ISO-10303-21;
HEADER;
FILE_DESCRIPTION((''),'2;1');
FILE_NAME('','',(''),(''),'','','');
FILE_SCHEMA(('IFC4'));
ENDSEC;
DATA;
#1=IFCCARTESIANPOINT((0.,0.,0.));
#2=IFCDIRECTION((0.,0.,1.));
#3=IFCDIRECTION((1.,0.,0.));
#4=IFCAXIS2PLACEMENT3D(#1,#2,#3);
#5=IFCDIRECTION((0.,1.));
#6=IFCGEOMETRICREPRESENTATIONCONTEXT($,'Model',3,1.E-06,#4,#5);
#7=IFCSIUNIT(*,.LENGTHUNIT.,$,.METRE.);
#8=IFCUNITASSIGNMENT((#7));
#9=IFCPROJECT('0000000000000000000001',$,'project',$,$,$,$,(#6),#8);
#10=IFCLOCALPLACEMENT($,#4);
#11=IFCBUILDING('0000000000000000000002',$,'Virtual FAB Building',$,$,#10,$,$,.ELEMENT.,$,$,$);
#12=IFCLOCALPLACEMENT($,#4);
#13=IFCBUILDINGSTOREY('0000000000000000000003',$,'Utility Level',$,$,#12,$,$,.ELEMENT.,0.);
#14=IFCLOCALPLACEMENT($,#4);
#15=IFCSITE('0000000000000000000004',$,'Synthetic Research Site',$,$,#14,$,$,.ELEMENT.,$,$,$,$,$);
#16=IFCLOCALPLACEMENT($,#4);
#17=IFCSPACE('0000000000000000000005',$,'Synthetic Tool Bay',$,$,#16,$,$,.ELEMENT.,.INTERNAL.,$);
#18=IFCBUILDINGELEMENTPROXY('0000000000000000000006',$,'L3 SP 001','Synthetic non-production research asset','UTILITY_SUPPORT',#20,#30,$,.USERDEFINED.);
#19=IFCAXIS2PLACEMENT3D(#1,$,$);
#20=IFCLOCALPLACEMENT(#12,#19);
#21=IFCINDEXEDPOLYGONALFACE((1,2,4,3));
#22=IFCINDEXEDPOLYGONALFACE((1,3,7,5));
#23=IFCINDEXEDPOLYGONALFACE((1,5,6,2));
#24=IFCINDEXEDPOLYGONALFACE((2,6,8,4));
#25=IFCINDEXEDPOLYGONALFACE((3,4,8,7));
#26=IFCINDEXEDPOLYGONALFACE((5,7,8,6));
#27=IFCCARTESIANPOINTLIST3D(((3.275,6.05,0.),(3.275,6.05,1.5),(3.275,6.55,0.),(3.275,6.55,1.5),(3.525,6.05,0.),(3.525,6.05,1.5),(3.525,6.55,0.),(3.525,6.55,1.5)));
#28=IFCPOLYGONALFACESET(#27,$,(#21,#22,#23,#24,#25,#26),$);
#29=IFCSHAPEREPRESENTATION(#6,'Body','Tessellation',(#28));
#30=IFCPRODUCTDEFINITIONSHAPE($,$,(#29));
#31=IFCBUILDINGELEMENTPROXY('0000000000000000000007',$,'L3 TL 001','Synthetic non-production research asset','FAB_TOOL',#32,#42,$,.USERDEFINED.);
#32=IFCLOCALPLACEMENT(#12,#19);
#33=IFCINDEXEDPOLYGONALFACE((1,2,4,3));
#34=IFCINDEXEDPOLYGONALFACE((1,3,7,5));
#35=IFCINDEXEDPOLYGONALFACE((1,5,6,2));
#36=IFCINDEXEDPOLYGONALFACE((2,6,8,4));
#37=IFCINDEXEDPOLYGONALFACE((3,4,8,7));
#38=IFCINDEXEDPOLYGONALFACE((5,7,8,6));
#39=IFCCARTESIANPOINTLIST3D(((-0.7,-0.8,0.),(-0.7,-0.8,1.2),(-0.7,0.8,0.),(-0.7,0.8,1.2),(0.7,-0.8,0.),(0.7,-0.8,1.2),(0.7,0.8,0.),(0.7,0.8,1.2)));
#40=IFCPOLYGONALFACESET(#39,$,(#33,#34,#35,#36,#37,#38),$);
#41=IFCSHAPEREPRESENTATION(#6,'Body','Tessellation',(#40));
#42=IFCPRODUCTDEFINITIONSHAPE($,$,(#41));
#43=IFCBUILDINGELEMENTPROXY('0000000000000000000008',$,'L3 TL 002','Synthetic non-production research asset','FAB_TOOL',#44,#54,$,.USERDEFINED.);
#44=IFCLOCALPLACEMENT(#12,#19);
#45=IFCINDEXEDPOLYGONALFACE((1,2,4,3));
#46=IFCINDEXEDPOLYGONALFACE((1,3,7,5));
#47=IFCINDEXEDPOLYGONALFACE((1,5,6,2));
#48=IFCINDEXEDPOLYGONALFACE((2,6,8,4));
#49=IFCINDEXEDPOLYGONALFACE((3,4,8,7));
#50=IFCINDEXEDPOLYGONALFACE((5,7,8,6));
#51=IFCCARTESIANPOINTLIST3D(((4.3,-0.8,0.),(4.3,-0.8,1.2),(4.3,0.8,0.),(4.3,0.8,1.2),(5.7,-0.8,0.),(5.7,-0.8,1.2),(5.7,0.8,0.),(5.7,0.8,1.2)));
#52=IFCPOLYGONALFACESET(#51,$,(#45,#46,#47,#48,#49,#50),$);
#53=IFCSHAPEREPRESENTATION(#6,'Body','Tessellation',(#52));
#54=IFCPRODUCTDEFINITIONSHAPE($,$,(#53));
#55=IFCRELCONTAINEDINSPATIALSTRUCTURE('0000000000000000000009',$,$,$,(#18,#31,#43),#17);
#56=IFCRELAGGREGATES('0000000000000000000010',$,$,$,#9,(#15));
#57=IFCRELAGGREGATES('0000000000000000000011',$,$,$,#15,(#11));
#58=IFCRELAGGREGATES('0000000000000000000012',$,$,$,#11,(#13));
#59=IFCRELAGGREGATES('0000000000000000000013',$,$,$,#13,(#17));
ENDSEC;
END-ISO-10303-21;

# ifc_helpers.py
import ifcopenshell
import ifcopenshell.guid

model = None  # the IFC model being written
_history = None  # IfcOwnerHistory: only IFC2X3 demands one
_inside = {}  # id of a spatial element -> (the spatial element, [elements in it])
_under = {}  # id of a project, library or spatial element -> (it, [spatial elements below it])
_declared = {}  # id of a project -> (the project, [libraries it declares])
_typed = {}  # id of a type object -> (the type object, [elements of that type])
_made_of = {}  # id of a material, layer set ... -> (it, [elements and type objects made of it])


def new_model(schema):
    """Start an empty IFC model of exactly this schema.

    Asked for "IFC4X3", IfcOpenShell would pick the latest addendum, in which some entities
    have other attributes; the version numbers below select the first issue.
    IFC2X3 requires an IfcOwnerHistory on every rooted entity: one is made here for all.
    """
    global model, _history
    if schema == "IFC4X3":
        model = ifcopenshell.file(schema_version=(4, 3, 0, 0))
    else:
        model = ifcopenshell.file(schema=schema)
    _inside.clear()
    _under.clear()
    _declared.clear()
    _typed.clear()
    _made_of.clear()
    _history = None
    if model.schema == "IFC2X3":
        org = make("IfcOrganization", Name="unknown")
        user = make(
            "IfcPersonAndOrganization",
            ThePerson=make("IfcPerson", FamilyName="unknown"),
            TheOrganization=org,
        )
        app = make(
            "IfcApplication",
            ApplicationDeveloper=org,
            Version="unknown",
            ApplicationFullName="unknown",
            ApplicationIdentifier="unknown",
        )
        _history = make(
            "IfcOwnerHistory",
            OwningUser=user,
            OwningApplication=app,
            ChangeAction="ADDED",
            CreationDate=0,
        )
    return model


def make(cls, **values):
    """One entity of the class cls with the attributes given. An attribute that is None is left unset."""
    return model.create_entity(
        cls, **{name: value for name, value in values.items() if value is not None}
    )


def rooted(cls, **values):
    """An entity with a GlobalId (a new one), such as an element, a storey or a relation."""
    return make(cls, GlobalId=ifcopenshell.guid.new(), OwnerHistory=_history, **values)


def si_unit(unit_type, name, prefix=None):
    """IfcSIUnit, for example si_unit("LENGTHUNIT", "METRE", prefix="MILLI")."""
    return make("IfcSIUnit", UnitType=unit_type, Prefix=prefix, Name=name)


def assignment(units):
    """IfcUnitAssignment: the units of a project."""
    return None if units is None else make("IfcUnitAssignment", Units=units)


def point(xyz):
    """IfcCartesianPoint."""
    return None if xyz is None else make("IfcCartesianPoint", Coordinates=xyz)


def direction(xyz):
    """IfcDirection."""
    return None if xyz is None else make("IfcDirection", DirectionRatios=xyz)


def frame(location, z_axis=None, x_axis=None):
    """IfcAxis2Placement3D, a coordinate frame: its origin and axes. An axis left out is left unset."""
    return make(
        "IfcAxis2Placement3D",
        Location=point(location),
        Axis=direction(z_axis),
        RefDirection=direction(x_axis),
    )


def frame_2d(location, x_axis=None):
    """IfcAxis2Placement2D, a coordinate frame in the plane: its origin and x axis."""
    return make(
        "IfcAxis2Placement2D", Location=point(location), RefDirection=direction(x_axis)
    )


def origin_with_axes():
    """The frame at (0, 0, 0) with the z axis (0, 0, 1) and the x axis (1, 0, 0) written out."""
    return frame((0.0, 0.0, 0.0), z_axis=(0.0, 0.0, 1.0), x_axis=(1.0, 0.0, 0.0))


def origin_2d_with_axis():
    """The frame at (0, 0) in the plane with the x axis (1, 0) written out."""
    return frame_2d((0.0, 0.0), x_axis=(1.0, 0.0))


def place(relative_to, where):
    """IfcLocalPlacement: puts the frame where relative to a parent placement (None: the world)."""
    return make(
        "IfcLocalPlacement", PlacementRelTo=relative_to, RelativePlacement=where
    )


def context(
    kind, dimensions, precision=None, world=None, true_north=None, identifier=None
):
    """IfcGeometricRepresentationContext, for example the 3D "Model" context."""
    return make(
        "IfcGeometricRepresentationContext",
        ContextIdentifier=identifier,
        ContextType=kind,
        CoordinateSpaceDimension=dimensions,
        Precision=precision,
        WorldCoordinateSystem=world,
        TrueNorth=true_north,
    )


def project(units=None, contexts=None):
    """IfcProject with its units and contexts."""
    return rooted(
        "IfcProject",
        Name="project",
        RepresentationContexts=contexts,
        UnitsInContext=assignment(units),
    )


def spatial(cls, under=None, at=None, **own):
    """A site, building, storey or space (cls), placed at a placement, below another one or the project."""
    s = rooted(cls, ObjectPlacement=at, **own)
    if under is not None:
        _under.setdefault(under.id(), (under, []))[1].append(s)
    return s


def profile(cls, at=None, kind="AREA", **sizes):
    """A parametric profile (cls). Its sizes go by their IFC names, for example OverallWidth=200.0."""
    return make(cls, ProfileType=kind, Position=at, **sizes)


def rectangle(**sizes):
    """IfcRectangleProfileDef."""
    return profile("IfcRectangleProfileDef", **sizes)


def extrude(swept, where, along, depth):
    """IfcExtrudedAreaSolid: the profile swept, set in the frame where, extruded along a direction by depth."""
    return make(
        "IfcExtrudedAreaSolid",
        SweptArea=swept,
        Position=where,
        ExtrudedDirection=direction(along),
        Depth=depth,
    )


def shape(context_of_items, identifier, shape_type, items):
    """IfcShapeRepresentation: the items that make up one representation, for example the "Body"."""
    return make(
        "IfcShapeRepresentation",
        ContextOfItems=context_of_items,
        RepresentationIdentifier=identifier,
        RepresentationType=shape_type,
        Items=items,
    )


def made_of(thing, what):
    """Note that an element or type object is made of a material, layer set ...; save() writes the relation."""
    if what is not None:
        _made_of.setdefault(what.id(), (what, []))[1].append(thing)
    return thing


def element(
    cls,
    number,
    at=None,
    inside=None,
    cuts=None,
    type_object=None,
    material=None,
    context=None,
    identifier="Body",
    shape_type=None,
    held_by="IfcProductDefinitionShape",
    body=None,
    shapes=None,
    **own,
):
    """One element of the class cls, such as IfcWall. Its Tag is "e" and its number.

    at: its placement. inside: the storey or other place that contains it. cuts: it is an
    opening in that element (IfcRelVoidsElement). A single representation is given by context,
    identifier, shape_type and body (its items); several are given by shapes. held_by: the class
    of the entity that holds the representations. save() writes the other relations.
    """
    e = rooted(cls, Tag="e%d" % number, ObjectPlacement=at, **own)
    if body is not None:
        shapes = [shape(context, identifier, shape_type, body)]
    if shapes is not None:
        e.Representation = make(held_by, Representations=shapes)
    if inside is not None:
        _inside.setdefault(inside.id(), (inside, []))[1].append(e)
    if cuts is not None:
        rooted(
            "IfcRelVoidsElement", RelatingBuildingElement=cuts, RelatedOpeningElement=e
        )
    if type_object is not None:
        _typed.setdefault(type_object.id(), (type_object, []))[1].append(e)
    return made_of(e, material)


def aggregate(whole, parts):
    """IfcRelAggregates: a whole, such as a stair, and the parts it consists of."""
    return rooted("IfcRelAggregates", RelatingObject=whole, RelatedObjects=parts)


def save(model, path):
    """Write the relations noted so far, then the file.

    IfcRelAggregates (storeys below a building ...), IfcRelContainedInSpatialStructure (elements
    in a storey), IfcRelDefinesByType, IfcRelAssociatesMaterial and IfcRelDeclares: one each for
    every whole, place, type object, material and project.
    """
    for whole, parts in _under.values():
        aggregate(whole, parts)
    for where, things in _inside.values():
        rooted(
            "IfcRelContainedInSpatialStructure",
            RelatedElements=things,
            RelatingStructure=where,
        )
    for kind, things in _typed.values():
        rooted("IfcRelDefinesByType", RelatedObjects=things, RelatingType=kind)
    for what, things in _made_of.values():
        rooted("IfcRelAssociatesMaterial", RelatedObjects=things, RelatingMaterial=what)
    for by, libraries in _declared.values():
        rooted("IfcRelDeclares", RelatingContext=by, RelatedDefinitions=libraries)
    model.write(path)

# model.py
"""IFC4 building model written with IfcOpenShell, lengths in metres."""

from ifc_helpers import new_model, si_unit, direction, frame, origin_with_axes, origin_2d_with_axis, place, context, project, spatial, rectangle, extrude, element, save


model = new_model("IFC4")

# Units and contexts
model_context = context("Model", 3, precision=1e-06, world=origin_with_axes(), true_north=direction((0.0, 1.0)))
ifc_project = project(units=[si_unit("LENGTHUNIT", "METRE")], contexts=[model_context])

# Site, building, storey, space
site_placement = place(None, origin_with_axes())
site = spatial("IfcSite", under=ifc_project, at=site_placement, Name="Synthetic Research Site", CompositionType="ELEMENT")
building_placement = place(None, origin_with_axes())
building = spatial("IfcBuilding", under=site, at=building_placement, Name="Virtual FAB Building", CompositionType="ELEMENT")
storey_placement = place(None, origin_with_axes())
storey = spatial("IfcBuildingStorey", under=building, at=storey_placement, Name="Utility Level", CompositionType="ELEMENT", Elevation=0.0)
space_placement = place(None, origin_with_axes())
space = spatial("IfcSpace", under=storey, at=space_placement, Name="Synthetic Tool Bay", CompositionType="ELEMENT", PredefinedType="INTERNAL")

# Building element proxies
proxy_placement = place(None, frame((3.4, 6.3, 0.0), z_axis=(0.0, 0.0, 1.0), x_axis=(1.0, 0.0, 0.0)))
element("IfcBuildingElementProxy", 1, at=proxy_placement, inside=space, Name="L3 SP 001", Description="Synthetic non-production research asset", ObjectType="UTILITY_SUPPORT", PredefinedType="USERDEFINED", context=model_context, shape_type="SweptSolid", body=[
    extrude(rectangle(XDim=0.25, YDim=0.5, at=origin_2d_with_axis()), origin_with_axes(), (0.0, 0.0, 1.0), 1.5),
])
for number, where, z_axis, x_axis, name in (
    (2, (0.0, 0.0, 0.0), (0.0, 0.0, 1.0), (1.0, 0.0, 0.0), "L3 TL 001"),
    (3, (5.0, 0.0, 0.0), (0.0, 0.0, 1.0), (1.0, 0.0, 0.0), "L3 TL 002"),
):
    element("IfcBuildingElementProxy", number, at=place(None, frame(where, z_axis=z_axis, x_axis=x_axis)), inside=space, Name=name, Description="Synthetic non-production research asset", ObjectType="FAB_TOOL", PredefinedType="USERDEFINED", context=model_context, shape_type="SweptSolid", body=[
        extrude(rectangle(XDim=1.4, YDim=1.6, at=origin_2d_with_axis()), origin_with_axes(), (0.0, 0.0, 1.0), 1.2),
    ])

save(model, "model.ifc")
